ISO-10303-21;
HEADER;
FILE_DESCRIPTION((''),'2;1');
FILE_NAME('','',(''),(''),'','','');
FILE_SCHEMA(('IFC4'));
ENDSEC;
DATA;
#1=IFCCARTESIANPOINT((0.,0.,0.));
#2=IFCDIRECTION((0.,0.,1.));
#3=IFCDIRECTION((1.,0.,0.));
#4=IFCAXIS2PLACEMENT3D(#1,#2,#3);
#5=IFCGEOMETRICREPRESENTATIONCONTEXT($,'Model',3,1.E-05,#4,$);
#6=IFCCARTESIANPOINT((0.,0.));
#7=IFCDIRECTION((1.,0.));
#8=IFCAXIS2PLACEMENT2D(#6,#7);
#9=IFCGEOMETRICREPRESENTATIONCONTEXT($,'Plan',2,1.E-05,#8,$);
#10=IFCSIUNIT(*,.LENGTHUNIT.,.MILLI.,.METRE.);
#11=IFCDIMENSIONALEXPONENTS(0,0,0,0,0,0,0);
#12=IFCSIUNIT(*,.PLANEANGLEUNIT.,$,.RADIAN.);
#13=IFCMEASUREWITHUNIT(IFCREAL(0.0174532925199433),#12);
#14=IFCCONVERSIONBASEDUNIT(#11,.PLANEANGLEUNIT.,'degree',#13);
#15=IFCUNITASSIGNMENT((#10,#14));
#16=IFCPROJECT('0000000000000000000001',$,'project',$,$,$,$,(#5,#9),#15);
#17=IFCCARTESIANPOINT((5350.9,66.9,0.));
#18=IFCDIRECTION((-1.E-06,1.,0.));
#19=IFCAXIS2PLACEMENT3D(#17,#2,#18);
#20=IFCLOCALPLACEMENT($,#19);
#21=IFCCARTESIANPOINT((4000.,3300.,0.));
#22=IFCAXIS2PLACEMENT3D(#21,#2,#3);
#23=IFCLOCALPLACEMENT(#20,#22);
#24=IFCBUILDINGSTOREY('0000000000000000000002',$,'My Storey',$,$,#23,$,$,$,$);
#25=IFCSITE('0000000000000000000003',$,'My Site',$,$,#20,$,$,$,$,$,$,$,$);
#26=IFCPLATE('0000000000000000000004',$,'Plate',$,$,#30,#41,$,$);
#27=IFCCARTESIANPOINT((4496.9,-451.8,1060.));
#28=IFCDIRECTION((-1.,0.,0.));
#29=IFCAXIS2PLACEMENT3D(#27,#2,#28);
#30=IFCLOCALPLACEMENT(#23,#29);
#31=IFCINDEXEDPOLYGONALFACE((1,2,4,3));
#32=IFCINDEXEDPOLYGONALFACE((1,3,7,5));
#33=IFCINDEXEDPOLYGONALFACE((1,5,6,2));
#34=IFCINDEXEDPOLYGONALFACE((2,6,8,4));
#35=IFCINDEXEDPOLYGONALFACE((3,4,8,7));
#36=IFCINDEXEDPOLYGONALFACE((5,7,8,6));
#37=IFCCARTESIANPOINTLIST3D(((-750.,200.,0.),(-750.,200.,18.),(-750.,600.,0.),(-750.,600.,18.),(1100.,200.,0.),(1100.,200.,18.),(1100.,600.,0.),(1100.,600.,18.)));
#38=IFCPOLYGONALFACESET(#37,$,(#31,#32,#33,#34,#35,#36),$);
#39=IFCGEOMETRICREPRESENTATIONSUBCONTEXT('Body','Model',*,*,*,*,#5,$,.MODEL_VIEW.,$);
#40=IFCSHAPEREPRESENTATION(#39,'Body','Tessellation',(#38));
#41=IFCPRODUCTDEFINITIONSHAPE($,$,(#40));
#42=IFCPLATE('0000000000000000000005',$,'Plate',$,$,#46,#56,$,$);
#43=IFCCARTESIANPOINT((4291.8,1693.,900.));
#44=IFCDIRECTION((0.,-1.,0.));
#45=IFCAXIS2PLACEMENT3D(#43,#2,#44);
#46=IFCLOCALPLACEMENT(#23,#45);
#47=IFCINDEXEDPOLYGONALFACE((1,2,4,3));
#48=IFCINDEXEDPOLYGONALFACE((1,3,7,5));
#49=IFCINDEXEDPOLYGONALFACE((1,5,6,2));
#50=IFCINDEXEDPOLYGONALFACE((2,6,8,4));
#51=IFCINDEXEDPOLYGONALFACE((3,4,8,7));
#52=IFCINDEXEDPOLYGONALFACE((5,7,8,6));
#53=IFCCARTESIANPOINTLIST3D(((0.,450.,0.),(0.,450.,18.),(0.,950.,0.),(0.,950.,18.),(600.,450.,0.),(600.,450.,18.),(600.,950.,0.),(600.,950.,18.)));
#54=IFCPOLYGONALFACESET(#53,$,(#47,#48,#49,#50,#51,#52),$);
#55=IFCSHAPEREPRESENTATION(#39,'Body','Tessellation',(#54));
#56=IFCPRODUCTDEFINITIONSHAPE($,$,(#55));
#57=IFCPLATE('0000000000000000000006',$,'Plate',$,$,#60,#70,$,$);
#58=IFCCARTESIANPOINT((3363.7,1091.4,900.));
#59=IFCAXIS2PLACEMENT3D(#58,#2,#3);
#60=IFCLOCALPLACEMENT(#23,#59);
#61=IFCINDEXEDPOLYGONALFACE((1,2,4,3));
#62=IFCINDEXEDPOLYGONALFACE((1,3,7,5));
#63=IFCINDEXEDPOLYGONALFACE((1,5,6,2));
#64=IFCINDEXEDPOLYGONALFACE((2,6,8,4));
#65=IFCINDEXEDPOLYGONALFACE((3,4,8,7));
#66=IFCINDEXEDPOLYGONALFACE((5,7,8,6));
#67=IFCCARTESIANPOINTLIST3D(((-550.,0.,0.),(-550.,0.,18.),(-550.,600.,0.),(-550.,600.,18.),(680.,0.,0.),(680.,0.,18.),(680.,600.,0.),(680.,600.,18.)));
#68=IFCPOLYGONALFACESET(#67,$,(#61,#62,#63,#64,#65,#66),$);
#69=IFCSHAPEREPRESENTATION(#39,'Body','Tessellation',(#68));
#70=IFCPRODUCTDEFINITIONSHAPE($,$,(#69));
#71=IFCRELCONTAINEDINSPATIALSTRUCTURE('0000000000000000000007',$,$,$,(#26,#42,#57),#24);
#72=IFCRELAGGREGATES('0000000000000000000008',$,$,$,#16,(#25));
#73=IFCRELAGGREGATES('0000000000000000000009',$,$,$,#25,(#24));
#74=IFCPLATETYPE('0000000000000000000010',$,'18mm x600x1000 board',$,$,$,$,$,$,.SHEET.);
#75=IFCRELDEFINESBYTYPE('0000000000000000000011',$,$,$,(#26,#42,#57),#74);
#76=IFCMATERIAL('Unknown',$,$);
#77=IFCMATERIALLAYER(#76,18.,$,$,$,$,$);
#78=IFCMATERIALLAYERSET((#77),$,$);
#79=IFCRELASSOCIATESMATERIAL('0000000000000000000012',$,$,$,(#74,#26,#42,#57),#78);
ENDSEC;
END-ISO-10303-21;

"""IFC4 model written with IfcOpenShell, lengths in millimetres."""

from ifc_helpers import new_model, entity, si_unit, converted_unit, frame, origin_with_axes, origin_2d_with_axis, place, context, subcontext, project, spatial, line, indexed_curve, outline, extrude, material, layer, layer_set, layer_usage, type_object, element, save


model = new_model("IFC4")

# Units and contexts
model_context = context("Model", 3, precision=1e-05, world=origin_with_axes())
plan_context = context("Plan", 2, precision=1e-05, world=origin_2d_with_axis())
body_context = subcontext(model_context, "Body", "Model", "MODEL_VIEW")
ifc_project = project(units=[si_unit("LENGTHUNIT", "METRE", prefix="MILLI"), converted_unit("PLANEANGLEUNIT", "degree", entity("IfcReal", 0.0174532925199433), si_unit("PLANEANGLEUNIT", "RADIAN"), dimensions=[0, 0, 0, 0, 0, 0, 0])], contexts=[model_context, plan_context])

# Site, storey
site_placement = place(None, frame((5350.9, 66.9, 0.0), z_axis=(0.0, 0.0, 1.0), x_axis=(-0.000001, 1.0, 0.0)))
site = spatial("IfcSite", under=ifc_project, at=site_placement, Name="My Site")
storey_placement = place(site_placement, frame((4000.0, 3300.0, 0.0), z_axis=(0.0, 0.0, 1.0), x_axis=(1.0, 0.0, 0.0)))
storey = spatial("IfcBuildingStorey", under=site, at=storey_placement, Name="My Storey")

# Shared definitions
ifc_material = material(Name="Unknown")

# Plates
ifc_layer_1 = layer(ifc_material, 18.0)
ifc_layer_set_1 = layer_set([ifc_layer_1])
ifc_layer_usage_1 = layer_usage(ifc_layer_set_1, "AXIS3", "POSITIVE", 0.0)
plate_type = type_object("IfcPlateType", Name="18mm x600x1000 board", PredefinedType="SHEET", material=ifc_layer_set_1)
plate_1_placement = place(storey_placement, frame((4496.9, -451.8, 1060.0), z_axis=(0.0, 0.0, 1.0), x_axis=(-1.0, 0.0, 0.0)))
element("IfcPlate", 1, at=plate_1_placement, inside=storey, type_object=plate_type, material=ifc_layer_usage_1, Name="Plate", context=body_context, shape_type="SweptSolid", body=[
    extrude(outline(indexed_curve([(-750.0, 200.0), (-750.0, 600.0), (1100.0, 600.0), (1100.0, 200.0)], segments=[line(3, 2), line(2, 1), line(1, 4), line(4, 3)], self_intersect=False)), None, (0.0, 0.0, 1.0), 18.0),
])
ifc_layer_usage_2 = layer_usage(ifc_layer_set_1, "AXIS3", "POSITIVE", 0.0)
plate_2_placement = place(storey_placement, frame((4291.8, 1693.0, 900.0), z_axis=(0.0, 0.0, 1.0), x_axis=(0.0, -1.0, 0.0)))
element("IfcPlate", 2, at=plate_2_placement, inside=storey, type_object=plate_type, material=ifc_layer_usage_2, Name="Plate", context=body_context, shape_type="SweptSolid", body=[
    extrude(outline(indexed_curve([(0.0, 950.0), (0.0, 450.0), (600.0, 450.0), (600.0, 950.0)], segments=[line(3, 2), line(2, 1), line(1, 4), line(4, 3)], self_intersect=False)), None, (0.0, 0.0, 1.0), 18.0),
])
ifc_layer_usage_3 = layer_usage(ifc_layer_set_1, "AXIS3", "POSITIVE", 0.0)
plate_3_placement = place(storey_placement, frame((3363.7, 1091.4, 900.0), z_axis=(0.0, 0.0, 1.0), x_axis=(1.0, 0.0, 0.0)))
element("IfcPlate", 3, at=plate_3_placement, inside=storey, type_object=plate_type, material=ifc_layer_usage_3, Name="Plate", context=body_context, shape_type="SweptSolid", body=[
    extrude(outline(indexed_curve([(-550.0, 600.0), (-550.0, 0.0), (680.0, 0.0), (680.0, 600.0)], segments=[line(3, 2), line(2, 1), line(1, 4), line(4, 3)], self_intersect=False)), None, (0.0, 0.0, 1.0), 18.0),
])

save(model, "model.ifc")
